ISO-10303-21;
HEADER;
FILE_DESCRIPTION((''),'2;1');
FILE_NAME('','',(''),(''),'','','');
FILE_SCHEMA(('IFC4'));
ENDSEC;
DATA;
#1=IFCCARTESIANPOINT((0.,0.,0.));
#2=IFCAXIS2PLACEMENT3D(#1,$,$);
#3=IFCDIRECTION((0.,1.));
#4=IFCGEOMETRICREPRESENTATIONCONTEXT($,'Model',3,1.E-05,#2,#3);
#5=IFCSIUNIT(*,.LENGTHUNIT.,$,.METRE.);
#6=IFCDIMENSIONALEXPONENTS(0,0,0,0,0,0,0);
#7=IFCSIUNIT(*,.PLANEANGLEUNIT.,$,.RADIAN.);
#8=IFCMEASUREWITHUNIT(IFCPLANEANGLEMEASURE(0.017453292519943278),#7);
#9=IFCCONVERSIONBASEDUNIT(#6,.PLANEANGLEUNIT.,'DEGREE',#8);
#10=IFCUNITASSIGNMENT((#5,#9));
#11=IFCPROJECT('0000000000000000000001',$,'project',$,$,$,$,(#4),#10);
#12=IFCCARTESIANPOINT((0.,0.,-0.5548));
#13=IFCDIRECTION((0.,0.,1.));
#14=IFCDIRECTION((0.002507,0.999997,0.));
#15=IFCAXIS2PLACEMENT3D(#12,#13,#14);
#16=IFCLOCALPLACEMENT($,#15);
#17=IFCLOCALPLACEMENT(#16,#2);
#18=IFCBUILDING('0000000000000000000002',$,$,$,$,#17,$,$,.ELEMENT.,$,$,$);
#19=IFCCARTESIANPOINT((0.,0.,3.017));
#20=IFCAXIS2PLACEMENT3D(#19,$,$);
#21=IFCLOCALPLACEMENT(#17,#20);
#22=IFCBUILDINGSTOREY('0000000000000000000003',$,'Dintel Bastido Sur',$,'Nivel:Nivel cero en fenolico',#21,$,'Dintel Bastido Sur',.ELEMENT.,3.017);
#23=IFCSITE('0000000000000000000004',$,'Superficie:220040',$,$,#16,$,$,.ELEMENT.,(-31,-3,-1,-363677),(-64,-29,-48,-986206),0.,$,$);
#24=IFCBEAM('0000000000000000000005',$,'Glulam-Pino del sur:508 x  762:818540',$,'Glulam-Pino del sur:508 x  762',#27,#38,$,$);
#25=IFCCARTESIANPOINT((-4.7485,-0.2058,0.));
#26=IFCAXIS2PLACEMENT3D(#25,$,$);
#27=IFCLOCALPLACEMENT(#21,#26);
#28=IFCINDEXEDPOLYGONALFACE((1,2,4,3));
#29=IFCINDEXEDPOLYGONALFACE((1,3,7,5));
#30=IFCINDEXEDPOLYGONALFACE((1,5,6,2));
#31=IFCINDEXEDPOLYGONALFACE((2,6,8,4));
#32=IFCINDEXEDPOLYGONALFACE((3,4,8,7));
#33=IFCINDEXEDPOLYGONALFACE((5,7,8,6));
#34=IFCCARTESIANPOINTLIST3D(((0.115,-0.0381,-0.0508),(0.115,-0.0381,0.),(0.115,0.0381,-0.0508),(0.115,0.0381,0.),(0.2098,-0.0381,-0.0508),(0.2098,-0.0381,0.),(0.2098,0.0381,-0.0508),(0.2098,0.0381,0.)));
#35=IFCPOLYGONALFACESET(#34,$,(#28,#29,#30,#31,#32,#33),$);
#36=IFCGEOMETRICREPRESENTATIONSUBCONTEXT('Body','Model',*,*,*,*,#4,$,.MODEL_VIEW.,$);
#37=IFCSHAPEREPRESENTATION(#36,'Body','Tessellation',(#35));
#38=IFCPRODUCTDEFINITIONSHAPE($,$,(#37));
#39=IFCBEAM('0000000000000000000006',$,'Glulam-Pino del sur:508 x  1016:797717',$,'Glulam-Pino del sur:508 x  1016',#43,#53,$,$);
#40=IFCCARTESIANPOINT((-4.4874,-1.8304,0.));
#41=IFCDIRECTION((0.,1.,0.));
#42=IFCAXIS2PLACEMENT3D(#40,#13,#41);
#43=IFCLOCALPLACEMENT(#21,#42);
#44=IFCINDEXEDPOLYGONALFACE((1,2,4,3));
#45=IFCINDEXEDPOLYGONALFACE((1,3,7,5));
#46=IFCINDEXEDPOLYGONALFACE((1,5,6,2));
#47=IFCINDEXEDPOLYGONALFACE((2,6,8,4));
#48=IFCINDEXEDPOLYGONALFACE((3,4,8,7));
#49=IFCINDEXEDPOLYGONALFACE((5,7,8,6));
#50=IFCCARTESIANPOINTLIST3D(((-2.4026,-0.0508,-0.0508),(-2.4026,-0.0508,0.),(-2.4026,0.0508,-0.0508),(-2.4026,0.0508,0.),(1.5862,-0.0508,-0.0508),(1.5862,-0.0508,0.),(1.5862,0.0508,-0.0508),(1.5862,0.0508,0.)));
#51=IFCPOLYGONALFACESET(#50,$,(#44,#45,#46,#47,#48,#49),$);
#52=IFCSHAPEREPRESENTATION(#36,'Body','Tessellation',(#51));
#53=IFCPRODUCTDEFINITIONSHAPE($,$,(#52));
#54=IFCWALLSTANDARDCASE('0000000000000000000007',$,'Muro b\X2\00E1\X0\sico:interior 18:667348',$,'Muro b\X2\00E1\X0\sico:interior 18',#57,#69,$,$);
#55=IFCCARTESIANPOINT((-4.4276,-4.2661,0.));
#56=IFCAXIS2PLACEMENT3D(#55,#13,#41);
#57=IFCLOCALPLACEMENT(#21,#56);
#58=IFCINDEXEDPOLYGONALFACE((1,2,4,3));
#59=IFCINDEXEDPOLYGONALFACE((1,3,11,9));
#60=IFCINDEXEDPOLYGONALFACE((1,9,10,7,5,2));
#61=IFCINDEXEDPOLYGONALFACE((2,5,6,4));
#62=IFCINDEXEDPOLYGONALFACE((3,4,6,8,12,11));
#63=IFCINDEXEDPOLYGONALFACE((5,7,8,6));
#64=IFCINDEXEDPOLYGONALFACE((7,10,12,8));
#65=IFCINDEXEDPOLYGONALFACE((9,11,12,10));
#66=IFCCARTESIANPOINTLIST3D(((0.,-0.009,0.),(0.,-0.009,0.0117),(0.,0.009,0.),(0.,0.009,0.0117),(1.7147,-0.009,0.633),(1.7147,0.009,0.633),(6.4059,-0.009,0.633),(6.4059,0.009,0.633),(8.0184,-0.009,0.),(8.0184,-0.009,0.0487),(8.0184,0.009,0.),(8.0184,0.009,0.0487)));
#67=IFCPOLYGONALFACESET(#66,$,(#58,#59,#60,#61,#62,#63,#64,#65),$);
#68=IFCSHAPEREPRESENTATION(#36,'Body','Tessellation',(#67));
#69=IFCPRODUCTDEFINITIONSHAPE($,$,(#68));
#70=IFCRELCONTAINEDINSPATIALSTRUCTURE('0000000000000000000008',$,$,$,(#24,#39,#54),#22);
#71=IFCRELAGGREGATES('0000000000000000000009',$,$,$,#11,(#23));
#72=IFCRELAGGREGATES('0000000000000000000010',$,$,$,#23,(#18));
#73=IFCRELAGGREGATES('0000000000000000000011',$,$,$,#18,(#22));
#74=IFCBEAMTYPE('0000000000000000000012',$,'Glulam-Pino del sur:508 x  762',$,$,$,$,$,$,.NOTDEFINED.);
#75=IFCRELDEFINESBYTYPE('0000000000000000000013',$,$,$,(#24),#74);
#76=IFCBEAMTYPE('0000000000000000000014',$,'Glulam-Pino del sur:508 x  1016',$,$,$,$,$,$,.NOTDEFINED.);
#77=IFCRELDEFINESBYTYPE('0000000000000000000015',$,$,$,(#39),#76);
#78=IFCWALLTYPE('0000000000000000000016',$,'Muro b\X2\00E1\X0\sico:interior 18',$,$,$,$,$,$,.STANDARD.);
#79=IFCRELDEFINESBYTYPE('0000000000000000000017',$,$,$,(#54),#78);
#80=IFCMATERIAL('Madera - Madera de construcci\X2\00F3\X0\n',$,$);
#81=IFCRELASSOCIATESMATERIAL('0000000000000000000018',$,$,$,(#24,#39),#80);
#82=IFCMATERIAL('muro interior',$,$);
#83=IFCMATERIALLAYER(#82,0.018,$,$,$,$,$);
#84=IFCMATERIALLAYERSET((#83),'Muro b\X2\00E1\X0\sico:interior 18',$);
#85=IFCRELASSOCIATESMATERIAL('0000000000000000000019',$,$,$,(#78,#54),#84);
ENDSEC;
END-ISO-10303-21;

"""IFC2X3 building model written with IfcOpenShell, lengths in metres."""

from ifc_helpers import new_model, entity, si_unit, converted_unit, direction, frame, frame_2d, origin, place, context, subcontext, project, spatial, polyline, rectangle, extrude, clip, halfspace, bounded_halfspace, material, layer, layer_set, layer_usage, type_object, element, save


model = new_model("IFC2X3")

# Units and contexts
model_context = context("Model", 3, precision=1e-05, world=origin(), true_north=direction((0.0, 1.0)))
body_context = subcontext(model_context, "Body", "Model", "MODEL_VIEW")
ifc_project = project(units=[si_unit("LENGTHUNIT", "METRE"), converted_unit("PLANEANGLEUNIT", "DEGREE", entity("IfcPlaneAngleMeasure", 0.017453292519943278), si_unit("PLANEANGLEUNIT", "RADIAN"), dimensions=[0, 0, 0, 0, 0, 0, 0])], contexts=[model_context])

# Site, building, storey
site_placement = place(None, frame((0.0, 0.0, -0.5548), z_axis=(0.0, 0.0, 1.0), x_axis=(0.002507, 0.999997, 0.0)))
site = spatial("IfcSite", under=ifc_project, at=site_placement, Name="Superficie:220040", CompositionType="ELEMENT", RefLatitude=(-31, -3, -1, -363677), RefLongitude=(-64, -29, -48, -986206), RefElevation=0.0)
building_placement = place(site_placement, origin())
building = spatial("IfcBuilding", under=site, at=building_placement, CompositionType="ELEMENT")
storey_placement = place(building_placement, frame((0.0, 0.0, 3.017)))
storey = spatial("IfcBuildingStorey", under=building, at=storey_placement, Name="Dintel Bastido Sur", ObjectType="Nivel:Nivel cero en fenolico", LongName="Dintel Bastido Sur", CompositionType="ELEMENT", Elevation=3.017)

# Shared definitions
ifc_material_1 = material(Name="Madera - Madera de construcción")

# Beams
beam_type_1 = type_object("IfcBeamType", Name="Glulam-Pino del sur:508 x  762", PredefinedType="NOTDEFINED")
beam_1_placement = place(storey_placement, frame((-4.7485, -0.2058, 0.0)))
element("IfcBeam", 1, at=beam_1_placement, inside=storey, type_object=beam_type_1, material=ifc_material_1, Name="Glulam-Pino del sur:508 x  762:818540", ObjectType="Glulam-Pino del sur:508 x  762", context=body_context, shape_type="SweptSolid", body=[
    extrude(rectangle(XDim=0.0508, YDim=0.0762, at=frame_2d((0.0, 0.0), x_axis=(1.0, 0.0))), frame((0.115, 0.0, -0.0254), z_axis=(1.0, 0.0, 0.0), x_axis=(0.0, 0.0, -1.0)), (0.0, 0.0, 1.0), 0.0948),
])
beam_type_2 = type_object("IfcBeamType", Name="Glulam-Pino del sur:508 x  1016", PredefinedType="NOTDEFINED")
beam_2_placement = place(storey_placement, frame((-4.4874, -1.8304, 0.0), z_axis=(0.0, 0.0, 1.0), x_axis=(0.0, 1.0, 0.0)))
element("IfcBeam", 2, at=beam_2_placement, inside=storey, type_object=beam_type_2, material=ifc_material_1, Name="Glulam-Pino del sur:508 x  1016:797717", ObjectType="Glulam-Pino del sur:508 x  1016", context=body_context, shape_type="SweptSolid", body=[
    extrude(rectangle(XDim=0.0508, YDim=0.1016, at=frame_2d((0.0, 0.0), x_axis=(1.0, 0.0))), frame((-2.4026, 0.0, -0.0254), z_axis=(1.0, 0.0, 0.0), x_axis=(0.0, 0.0, -1.0)), (0.0, 0.0, 1.0), 3.9888),
])

# Wall
ifc_material_2 = material(Name="muro interior")
ifc_layer = layer(ifc_material_2, 0.018)
ifc_layer_set = layer_set([ifc_layer], Name="Muro básico:interior 18")
ifc_layer_usage = layer_usage(ifc_layer_set, "AXIS2", "NEGATIVE", 0.009)
wall_type = type_object("IfcWallType", Name="Muro básico:interior 18", PredefinedType="STANDARD", material=ifc_layer_set)
wall_placement = place(storey_placement, frame((-4.4276, -4.2661, 0.0), z_axis=(0.0, 0.0, 1.0), x_axis=(0.0, 1.0, 0.0)))
element("IfcWallStandardCase", 3, at=wall_placement, inside=storey, type_object=wall_type, material=ifc_layer_usage, Name="Muro básico:interior 18:667348", ObjectType="Muro básico:interior 18", context=body_context, shape_type="Clipping", body=[
    clip(clip(clip(extrude(rectangle(XDim=8.0184, YDim=0.018, at=frame_2d((4.0092, 0.0), x_axis=(-1.0, 0.0))), origin(), (0.0, 0.0, 1.0), 0.633), bounded_halfspace(frame((4.0603, -0.009, 1.483), z_axis=(0.340697, 0.0, 0.940173), x_axis=(0.0, -1.0, 0.0)), False, frame((4.0603, -0.009, 1.483)), polyline([(0.0, 0.0), (3.9581, 0.0), (3.9581, 0.018), (0.0, 0.018), (0.0, 0.0)]))), bounded_halfspace(frame((0.0, -0.009, 0.0117), z_axis=(-0.340697, 0.0, 0.940173), x_axis=(0.0, 1.0, 0.0)), False, frame((0.0, -0.009, 0.0117)), polyline([(0.0, 0.0), (4.0603, 0.0), (4.0603, 0.018), (0.0, 0.018), (0.0, 0.0)]))), halfspace(frame((0.0, 0.0, -2.9662)), True)),
])

save(model, "model.ifc")
